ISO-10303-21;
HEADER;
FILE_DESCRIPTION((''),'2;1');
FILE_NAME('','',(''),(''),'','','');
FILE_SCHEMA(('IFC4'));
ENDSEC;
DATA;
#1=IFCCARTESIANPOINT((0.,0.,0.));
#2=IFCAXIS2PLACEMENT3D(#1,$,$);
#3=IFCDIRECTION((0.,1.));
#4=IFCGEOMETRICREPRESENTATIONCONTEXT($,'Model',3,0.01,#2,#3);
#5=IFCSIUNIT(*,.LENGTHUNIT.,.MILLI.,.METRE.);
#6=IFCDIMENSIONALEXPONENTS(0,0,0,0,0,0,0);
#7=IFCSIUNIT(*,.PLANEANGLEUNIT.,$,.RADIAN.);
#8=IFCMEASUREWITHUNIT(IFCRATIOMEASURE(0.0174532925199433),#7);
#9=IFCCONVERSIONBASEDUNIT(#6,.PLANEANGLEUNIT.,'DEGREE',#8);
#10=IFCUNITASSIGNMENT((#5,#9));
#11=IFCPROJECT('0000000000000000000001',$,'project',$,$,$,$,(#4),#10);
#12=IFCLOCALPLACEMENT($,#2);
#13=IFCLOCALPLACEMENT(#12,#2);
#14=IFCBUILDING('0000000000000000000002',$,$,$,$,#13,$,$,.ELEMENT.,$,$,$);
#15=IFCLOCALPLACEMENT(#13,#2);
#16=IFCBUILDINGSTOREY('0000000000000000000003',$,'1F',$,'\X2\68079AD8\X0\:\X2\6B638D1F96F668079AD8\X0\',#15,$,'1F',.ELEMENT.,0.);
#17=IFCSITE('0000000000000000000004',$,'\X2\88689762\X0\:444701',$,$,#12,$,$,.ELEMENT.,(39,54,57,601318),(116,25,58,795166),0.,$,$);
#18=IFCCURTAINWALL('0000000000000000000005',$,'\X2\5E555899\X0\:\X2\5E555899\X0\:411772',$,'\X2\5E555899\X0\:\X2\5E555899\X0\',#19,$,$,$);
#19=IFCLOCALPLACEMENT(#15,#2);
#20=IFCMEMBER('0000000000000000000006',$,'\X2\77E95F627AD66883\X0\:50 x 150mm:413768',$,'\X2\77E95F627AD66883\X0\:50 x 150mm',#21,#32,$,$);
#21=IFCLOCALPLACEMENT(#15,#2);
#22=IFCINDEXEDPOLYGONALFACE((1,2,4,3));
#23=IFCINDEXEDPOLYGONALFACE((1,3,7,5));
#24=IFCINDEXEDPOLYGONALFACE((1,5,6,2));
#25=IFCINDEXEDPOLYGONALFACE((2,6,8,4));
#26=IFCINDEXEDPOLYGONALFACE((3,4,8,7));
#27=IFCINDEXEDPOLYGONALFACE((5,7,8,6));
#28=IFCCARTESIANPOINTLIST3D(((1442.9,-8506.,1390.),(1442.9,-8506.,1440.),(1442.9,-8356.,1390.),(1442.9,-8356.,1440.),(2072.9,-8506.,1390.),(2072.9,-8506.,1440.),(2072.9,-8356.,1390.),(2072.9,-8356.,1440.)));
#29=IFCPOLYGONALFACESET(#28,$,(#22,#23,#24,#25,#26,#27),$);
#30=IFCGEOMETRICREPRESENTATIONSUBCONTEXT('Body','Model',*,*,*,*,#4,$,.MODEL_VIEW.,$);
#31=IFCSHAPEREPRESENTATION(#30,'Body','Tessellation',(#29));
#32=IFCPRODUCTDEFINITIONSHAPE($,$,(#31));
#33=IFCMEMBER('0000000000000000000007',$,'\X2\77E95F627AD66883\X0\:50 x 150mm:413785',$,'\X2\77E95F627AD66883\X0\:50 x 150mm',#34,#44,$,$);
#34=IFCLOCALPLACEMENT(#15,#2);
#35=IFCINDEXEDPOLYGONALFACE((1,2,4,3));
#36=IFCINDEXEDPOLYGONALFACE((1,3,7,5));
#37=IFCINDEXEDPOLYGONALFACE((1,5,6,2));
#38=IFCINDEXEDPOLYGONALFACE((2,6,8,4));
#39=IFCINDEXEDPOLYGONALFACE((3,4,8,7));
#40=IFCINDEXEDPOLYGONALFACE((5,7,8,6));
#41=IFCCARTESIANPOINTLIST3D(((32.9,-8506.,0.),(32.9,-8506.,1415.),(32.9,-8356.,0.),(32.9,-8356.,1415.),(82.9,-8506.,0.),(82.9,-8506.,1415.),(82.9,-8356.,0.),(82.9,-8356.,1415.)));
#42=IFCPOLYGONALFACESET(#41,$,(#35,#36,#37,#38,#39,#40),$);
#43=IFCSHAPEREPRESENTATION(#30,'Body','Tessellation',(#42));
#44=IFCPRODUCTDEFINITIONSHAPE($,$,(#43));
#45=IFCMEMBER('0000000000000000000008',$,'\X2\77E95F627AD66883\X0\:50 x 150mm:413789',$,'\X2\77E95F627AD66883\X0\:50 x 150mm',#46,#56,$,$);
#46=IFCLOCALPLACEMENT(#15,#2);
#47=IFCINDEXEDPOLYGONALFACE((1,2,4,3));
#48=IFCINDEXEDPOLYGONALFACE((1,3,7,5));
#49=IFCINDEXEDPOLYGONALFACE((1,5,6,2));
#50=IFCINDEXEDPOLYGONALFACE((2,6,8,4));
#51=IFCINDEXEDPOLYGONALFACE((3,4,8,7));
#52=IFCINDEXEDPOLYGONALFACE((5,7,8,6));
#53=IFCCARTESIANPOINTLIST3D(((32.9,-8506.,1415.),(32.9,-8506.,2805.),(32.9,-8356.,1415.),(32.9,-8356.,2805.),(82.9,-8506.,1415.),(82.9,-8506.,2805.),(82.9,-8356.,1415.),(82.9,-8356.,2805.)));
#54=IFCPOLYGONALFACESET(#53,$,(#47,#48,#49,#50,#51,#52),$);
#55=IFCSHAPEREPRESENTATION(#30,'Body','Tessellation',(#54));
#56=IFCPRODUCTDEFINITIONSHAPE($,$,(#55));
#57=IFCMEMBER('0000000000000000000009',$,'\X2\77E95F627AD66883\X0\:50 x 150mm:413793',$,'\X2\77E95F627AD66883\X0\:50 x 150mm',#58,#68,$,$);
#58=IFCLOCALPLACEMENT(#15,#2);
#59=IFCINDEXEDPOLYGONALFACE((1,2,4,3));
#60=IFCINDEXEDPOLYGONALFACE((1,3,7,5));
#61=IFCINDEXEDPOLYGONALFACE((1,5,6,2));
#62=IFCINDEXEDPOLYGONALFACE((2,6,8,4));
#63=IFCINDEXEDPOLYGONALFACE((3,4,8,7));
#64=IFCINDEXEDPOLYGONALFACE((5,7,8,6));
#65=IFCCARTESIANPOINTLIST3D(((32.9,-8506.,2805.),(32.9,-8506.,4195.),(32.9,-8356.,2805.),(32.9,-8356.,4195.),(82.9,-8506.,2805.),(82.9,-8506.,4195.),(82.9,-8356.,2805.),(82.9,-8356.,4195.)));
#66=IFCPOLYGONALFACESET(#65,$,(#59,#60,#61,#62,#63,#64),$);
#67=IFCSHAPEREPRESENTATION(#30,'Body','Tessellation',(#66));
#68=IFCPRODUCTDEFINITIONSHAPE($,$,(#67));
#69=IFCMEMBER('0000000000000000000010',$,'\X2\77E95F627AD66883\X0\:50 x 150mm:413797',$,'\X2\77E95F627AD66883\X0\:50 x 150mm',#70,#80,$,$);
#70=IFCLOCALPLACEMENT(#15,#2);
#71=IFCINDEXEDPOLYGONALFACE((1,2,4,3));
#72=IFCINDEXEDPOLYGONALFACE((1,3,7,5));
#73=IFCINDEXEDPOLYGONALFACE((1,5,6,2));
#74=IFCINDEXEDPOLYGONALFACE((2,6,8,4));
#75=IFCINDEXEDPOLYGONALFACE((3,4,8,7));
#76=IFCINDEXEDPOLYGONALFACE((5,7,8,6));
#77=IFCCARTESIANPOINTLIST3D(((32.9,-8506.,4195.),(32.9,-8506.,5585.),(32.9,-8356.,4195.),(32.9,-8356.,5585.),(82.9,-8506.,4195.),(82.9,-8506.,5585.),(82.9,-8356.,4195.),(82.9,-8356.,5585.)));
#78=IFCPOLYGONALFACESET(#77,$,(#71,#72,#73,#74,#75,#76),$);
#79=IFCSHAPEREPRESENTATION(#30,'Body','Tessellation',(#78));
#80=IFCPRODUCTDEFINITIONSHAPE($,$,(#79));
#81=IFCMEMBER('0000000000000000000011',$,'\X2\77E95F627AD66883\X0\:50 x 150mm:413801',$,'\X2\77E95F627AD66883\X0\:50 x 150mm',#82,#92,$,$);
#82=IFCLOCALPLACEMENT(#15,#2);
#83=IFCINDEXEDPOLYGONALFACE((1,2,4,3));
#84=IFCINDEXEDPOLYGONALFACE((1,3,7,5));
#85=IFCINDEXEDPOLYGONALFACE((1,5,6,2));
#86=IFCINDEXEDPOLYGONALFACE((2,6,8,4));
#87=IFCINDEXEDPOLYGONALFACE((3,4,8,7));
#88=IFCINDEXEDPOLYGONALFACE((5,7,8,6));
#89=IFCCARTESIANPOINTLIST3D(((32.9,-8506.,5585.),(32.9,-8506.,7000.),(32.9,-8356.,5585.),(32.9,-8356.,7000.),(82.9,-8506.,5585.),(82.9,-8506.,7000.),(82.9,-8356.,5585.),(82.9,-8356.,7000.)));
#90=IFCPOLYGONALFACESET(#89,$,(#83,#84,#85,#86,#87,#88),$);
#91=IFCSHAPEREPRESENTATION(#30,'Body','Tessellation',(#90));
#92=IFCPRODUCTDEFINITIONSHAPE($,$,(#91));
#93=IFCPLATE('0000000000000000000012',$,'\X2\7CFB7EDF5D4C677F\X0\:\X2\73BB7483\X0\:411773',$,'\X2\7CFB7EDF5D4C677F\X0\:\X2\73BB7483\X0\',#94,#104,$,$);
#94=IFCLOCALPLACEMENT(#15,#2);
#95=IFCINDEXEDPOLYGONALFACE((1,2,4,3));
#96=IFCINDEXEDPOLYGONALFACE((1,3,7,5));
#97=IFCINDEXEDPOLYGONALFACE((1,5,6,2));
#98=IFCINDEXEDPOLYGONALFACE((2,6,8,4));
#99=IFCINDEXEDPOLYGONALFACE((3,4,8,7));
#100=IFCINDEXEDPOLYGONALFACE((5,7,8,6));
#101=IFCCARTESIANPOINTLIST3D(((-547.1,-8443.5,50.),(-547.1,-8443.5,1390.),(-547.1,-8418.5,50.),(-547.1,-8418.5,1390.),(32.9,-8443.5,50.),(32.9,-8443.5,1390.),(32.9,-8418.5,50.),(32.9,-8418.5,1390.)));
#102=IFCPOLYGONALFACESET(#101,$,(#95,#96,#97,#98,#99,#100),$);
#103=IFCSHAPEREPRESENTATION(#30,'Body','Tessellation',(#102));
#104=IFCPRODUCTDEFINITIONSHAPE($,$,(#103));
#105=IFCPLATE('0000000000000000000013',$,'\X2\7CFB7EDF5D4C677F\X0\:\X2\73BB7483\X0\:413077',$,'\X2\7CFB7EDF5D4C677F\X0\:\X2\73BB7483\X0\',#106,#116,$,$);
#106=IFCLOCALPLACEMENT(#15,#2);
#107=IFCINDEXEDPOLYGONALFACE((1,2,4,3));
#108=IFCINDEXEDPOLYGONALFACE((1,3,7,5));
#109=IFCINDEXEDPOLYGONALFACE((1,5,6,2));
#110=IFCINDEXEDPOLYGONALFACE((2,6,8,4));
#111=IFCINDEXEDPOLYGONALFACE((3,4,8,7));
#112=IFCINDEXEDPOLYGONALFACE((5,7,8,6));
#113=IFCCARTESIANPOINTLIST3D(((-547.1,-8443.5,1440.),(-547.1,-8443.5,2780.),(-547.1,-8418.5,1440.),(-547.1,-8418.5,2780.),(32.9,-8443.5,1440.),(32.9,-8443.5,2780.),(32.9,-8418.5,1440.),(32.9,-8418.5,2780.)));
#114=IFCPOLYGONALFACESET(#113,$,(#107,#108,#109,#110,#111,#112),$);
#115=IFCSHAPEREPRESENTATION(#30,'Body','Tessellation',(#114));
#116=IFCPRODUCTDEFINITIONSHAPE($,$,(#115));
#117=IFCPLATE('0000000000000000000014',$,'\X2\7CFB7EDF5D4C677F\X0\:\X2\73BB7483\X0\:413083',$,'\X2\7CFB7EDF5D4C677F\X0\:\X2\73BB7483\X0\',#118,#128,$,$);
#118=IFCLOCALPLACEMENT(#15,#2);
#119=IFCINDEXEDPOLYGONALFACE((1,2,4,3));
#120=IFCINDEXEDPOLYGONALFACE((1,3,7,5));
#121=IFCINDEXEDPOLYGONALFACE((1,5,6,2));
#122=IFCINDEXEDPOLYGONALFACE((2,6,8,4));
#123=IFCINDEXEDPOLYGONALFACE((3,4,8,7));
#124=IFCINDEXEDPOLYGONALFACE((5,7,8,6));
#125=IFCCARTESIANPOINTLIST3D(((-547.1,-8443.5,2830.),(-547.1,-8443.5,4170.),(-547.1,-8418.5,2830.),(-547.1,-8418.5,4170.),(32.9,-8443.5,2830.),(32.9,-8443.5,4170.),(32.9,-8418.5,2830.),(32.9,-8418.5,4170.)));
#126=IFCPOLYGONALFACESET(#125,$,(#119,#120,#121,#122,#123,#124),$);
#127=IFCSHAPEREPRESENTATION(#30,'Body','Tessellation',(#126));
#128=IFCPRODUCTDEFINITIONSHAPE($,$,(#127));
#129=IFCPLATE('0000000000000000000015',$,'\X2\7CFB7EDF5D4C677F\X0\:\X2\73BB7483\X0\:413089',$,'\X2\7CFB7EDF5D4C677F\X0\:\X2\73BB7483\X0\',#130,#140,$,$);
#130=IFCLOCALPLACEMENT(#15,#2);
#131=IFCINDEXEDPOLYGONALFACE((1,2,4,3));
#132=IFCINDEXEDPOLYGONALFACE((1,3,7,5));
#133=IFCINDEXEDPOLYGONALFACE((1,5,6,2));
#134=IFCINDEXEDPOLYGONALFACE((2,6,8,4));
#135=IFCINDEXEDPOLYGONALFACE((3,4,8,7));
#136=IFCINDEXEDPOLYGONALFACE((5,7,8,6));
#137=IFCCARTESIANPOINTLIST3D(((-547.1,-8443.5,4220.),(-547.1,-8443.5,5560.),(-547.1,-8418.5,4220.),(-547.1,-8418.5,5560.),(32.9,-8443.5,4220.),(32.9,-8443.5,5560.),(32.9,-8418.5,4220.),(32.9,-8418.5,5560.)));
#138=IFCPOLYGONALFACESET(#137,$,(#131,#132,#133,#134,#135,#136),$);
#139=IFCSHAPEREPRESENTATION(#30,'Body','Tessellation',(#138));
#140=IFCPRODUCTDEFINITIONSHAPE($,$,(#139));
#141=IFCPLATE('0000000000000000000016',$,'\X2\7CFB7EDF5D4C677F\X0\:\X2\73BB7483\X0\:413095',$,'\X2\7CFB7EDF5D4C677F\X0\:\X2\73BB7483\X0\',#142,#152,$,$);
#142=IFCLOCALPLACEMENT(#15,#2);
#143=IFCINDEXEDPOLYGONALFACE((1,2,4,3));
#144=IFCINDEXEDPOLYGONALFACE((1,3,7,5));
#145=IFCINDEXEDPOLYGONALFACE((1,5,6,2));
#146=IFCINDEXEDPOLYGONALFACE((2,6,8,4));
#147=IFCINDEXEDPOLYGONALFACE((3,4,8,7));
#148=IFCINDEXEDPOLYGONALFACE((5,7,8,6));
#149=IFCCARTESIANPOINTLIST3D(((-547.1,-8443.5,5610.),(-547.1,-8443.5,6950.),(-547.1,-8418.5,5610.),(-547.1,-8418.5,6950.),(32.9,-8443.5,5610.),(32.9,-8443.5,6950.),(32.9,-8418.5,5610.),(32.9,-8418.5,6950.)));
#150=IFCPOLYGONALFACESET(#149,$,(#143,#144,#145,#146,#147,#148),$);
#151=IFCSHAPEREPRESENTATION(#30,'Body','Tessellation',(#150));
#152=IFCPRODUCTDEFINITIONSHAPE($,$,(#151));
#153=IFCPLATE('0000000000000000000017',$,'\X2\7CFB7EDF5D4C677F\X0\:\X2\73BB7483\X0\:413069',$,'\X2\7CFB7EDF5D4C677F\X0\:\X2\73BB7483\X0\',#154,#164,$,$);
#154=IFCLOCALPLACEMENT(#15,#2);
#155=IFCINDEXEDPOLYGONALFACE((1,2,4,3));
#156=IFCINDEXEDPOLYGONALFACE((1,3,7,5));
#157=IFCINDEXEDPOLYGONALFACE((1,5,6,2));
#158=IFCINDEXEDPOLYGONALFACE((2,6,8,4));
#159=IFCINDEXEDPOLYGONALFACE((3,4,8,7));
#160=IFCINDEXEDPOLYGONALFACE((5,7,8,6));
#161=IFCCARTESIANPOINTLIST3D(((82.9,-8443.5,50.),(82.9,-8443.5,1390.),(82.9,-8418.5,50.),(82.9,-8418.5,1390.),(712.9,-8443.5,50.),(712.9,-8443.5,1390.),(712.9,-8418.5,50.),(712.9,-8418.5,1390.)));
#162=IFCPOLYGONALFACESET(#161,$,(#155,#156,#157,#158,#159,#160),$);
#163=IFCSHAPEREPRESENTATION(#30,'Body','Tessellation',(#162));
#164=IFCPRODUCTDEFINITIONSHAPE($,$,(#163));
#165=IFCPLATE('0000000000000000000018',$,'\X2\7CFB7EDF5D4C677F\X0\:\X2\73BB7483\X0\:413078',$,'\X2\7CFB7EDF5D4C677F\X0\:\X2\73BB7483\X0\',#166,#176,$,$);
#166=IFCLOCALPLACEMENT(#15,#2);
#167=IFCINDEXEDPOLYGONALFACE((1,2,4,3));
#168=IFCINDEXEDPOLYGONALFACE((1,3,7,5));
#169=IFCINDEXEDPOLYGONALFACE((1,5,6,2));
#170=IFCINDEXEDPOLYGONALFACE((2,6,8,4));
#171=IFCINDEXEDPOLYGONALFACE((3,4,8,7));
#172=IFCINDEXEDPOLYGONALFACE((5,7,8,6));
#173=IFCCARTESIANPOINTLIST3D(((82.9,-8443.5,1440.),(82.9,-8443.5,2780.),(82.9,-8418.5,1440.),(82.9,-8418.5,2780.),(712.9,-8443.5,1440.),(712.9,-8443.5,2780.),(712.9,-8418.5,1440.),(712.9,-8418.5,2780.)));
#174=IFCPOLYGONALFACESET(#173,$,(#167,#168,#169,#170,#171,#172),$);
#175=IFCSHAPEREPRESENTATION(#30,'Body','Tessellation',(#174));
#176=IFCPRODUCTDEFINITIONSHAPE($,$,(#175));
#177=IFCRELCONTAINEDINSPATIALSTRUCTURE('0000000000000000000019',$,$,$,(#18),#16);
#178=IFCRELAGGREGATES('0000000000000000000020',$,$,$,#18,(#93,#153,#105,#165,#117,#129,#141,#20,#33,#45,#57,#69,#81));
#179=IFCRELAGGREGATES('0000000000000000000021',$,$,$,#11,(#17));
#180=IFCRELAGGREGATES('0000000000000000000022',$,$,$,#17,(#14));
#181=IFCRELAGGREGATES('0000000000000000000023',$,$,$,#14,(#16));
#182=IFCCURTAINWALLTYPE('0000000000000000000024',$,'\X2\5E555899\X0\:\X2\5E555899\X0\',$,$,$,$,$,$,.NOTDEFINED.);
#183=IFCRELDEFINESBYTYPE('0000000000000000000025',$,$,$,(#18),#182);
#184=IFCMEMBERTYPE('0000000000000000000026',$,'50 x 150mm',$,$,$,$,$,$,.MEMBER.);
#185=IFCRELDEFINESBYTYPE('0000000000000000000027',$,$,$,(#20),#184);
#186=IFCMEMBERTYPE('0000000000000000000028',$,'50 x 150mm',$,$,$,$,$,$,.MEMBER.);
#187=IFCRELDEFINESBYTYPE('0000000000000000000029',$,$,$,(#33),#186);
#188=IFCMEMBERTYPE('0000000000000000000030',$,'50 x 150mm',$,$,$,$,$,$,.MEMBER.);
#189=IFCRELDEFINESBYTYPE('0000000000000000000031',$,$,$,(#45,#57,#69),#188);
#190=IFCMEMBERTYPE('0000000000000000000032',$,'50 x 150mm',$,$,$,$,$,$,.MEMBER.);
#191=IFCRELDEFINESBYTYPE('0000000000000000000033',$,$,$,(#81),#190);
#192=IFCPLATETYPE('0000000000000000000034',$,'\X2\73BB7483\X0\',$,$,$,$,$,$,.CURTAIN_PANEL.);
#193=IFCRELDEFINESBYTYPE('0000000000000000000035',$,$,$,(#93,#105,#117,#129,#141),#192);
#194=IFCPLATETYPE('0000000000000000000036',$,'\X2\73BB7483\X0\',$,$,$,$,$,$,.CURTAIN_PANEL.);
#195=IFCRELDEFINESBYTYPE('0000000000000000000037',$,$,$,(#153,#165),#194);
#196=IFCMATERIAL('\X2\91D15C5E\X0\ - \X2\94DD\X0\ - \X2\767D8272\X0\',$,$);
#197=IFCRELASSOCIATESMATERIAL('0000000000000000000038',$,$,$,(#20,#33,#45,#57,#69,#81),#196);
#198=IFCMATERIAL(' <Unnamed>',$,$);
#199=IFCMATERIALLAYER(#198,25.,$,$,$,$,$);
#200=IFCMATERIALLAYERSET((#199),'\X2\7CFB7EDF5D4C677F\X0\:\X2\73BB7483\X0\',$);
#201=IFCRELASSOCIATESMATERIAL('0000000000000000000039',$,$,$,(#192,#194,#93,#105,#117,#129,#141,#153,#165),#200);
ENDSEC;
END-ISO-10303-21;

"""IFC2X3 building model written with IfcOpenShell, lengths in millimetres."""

from ifc_helpers import new_model, entity, si_unit, converted_unit, direction, frame, origin, origin_2d_with_axis, place, context, subcontext, project, spatial, rectangle, extrude, source, transform, mapped, material, layer, layer_set, layer_usage, type_object, type_shapes, element, aggregate, save


model = new_model("IFC2X3")

# Units and contexts
model_context = context("Model", 3, precision=0.01, world=origin(), true_north=direction((0.0, 1.0)))
body_context = subcontext(model_context, "Body", "Model", "MODEL_VIEW")
ifc_project = project(units=[si_unit("LENGTHUNIT", "METRE", prefix="MILLI"), converted_unit("PLANEANGLEUNIT", "DEGREE", entity("IfcRatioMeasure", 0.0174532925199433), si_unit("PLANEANGLEUNIT", "RADIAN"), dimensions=[0, 0, 0, 0, 0, 0, 0])], contexts=[model_context])

# Site, building, storey
site_placement = place(None, origin())
site = spatial("IfcSite", under=ifc_project, at=site_placement, Name="表面:444701", CompositionType="ELEMENT", RefLatitude=(39, 54, 57, 601318), RefLongitude=(116, 25, 58, 795166), RefElevation=0.0)
building_placement = place(site_placement, origin())
building = spatial("IfcBuilding", under=site, at=building_placement, CompositionType="ELEMENT")
storey_placement = place(building_placement, origin())
storey = spatial("IfcBuildingStorey", under=building, at=storey_placement, Name="1F", ObjectType="标高:正负零标高", LongName="1F", CompositionType="ELEMENT", Elevation=0.0)

# Curtain wall, members, plates
curtain_wall_type = type_object("IfcCurtainWallType", Name="幕墙:幕墙", PredefinedType="NOTDEFINED")
curtain_wall_placement = place(storey_placement, origin())
curtain_wall = element("IfcCurtainWall", 1, at=curtain_wall_placement, inside=storey, type_object=curtain_wall_type, Name="幕墙:幕墙:411772", ObjectType="幕墙:幕墙")
ifc_material_1 = material(Name="金属 - 铝 - 白色")
member_type_1 = type_object("IfcMemberType", Name="50 x 150mm", PredefinedType="MEMBER")
shared_shape_1 = source(origin(), body_context, "Body", "SweptSolid", [
    extrude(rectangle(XDim=150.0, YDim=50.0, at=origin_2d_with_axis()), frame((0.0, 0.0, -630.0), z_axis=(0.0, 0.0, 1.0), x_axis=(0.0, -1.0, 0.0)), (0.0, 0.0, 1.0), 630.0),
])
type_shapes(member_type_1, [shared_shape_1])
member_1_placement = place(storey_placement, frame((2072.9, -8431.0, 1415.0), z_axis=(1.0, 0.0, 0.0), x_axis=(0.0, 0.0, 1.0)))
member_1 = element("IfcMember", 2, at=member_1_placement, type_object=member_type_1, material=ifc_material_1, Name="矩形竖梃:50 x 150mm:413768", ObjectType="矩形竖梃:50 x 150mm", context=body_context, shape_type="MappedRepresentation", body=[
    mapped(shared_shape_1, transform((0.0, 0.0, 0.0), scale=1.0)),
])
member_type_2 = type_object("IfcMemberType", Name="50 x 150mm", PredefinedType="MEMBER")
shared_shape_2 = source(origin(), body_context, "Body", "SweptSolid", [
    extrude(rectangle(XDim=150.0, YDim=50.0, at=origin_2d_with_axis()), frame((0.0, 0.0, -1415.0), z_axis=(0.0, 0.0, 1.0), x_axis=(0.0, -1.0, 0.0)), (0.0, 0.0, 1.0), 1415.0),
])
type_shapes(member_type_2, [shared_shape_2])
member_2_placement = place(storey_placement, frame((57.9, -8431.0, 0.0), z_axis=(0.0, 0.0, -1.0), x_axis=(1.0, 0.0, 0.0)))
member_2 = element("IfcMember", 3, at=member_2_placement, type_object=member_type_2, material=ifc_material_1, Name="矩形竖梃:50 x 150mm:413785", ObjectType="矩形竖梃:50 x 150mm", context=body_context, shape_type="MappedRepresentation", body=[
    mapped(shared_shape_2, transform((0.0, 0.0, 0.0), scale=1.0)),
])
member_type_3 = type_object("IfcMemberType", Name="50 x 150mm", PredefinedType="MEMBER")
shared_shape_3 = source(origin(), body_context, "Body", "SweptSolid", [
    extrude(rectangle(XDim=150.0, YDim=50.0, at=origin_2d_with_axis()), frame((0.0, 0.0, -1390.0), z_axis=(0.0, 0.0, 1.0), x_axis=(0.0, -1.0, 0.0)), (0.0, 0.0, 1.0), 1390.0),
])
type_shapes(member_type_3, [shared_shape_3])
member_3_placement = place(storey_placement, frame((57.9, -8431.0, 1415.0), z_axis=(0.0, 0.0, -1.0), x_axis=(1.0, 0.0, 0.0)))
member_3 = element("IfcMember", 4, at=member_3_placement, type_object=member_type_3, material=ifc_material_1, Name="矩形竖梃:50 x 150mm:413789", ObjectType="矩形竖梃:50 x 150mm", context=body_context, shape_type="MappedRepresentation", body=[
    mapped(shared_shape_3, transform((0.0, 0.0, 0.0), scale=1.0)),
])
member_4_placement = place(storey_placement, frame((57.9, -8431.0, 2805.0), z_axis=(0.0, 0.0, -1.0), x_axis=(1.0, 0.0, 0.0)))
member_4 = element("IfcMember", 5, at=member_4_placement, type_object=member_type_3, material=ifc_material_1, Name="矩形竖梃:50 x 150mm:413793", ObjectType="矩形竖梃:50 x 150mm", context=body_context, shape_type="MappedRepresentation", body=[
    mapped(shared_shape_3, transform((0.0, 0.0, 0.0), scale=1.0)),
])
member_5_placement = place(storey_placement, frame((57.9, -8431.0, 4195.0), z_axis=(0.0, 0.0, -1.0), x_axis=(1.0, 0.0, 0.0)))
member_5 = element("IfcMember", 6, at=member_5_placement, type_object=member_type_3, material=ifc_material_1, Name="矩形竖梃:50 x 150mm:413797", ObjectType="矩形竖梃:50 x 150mm", context=body_context, shape_type="MappedRepresentation", body=[
    mapped(shared_shape_3, transform((0.0, 0.0, 0.0), scale=1.0)),
])
member_type_4 = type_object("IfcMemberType", Name="50 x 150mm", PredefinedType="MEMBER")
shared_shape_4 = source(origin(), body_context, "Body", "SweptSolid", [
    extrude(rectangle(XDim=150.0, YDim=50.0, at=origin_2d_with_axis()), frame((0.0, 0.0, -1415.0), z_axis=(0.0, 0.0, 1.0), x_axis=(0.0, -1.0, 0.0)), (0.0, 0.0, 1.0), 1415.0),
])
type_shapes(member_type_4, [shared_shape_4])
member_6_placement = place(storey_placement, frame((57.9, -8431.0, 5585.0), z_axis=(0.0, 0.0, -1.0), x_axis=(1.0, 0.0, 0.0)))
member_6 = element("IfcMember", 7, at=member_6_placement, type_object=member_type_4, material=ifc_material_1, Name="矩形竖梃:50 x 150mm:413801", ObjectType="矩形竖梃:50 x 150mm", context=body_context, shape_type="MappedRepresentation", body=[
    mapped(shared_shape_4, transform((0.0, 0.0, 0.0), scale=1.0)),
])
ifc_material_2 = material(Name=" <Unnamed>")
ifc_layer_1 = layer(ifc_material_2, 25.0)
ifc_layer_set_1 = layer_set([ifc_layer_1], Name="系统嵌板:玻璃")
ifc_layer_usage_1 = layer_usage(ifc_layer_set_1, "AXIS3", "POSITIVE", 0.0)
plate_type_1 = type_object("IfcPlateType", Name="玻璃", PredefinedType="CURTAIN_PANEL", material=ifc_layer_set_1)
shared_shape_5 = source(origin(), body_context, "Body", "SweptSolid", [
    extrude(rectangle(XDim=25.0, YDim=580.0, at=origin_2d_with_axis()), frame((0.0, 0.0, 0.0), z_axis=(0.0, 0.0, 1.0), x_axis=(0.0, 1.0, 0.0)), (0.0, 0.0, 1.0), 1340.0),
])
type_shapes(plate_type_1, [shared_shape_5])
plate_1_placement = place(curtain_wall_placement, frame((-257.1, -8431.0, 50.0)))
plate_1 = element("IfcPlate", 8, at=plate_1_placement, type_object=plate_type_1, material=ifc_layer_usage_1, Name="系统嵌板:玻璃:411773", ObjectType="系统嵌板:玻璃", context=body_context, shape_type="MappedRepresentation", body=[
    mapped(shared_shape_5, transform((0.0, 0.0, 0.0), scale=1.0)),
])
ifc_layer_usage_2 = layer_usage(ifc_layer_set_1, "AXIS3", "POSITIVE", 0.0)
plate_2_placement = place(curtain_wall_placement, frame((-257.1, -8431.0, 1440.0)))
plate_2 = element("IfcPlate", 9, at=plate_2_placement, type_object=plate_type_1, material=ifc_layer_usage_2, Name="系统嵌板:玻璃:413077", ObjectType="系统嵌板:玻璃", context=body_context, shape_type="MappedRepresentation", body=[
    mapped(shared_shape_5, transform((0.0, 0.0, 0.0), scale=1.0)),
])
ifc_layer_usage_3 = layer_usage(ifc_layer_set_1, "AXIS3", "POSITIVE", 0.0)
plate_3_placement = place(curtain_wall_placement, frame((-257.1, -8431.0, 2830.0)))
plate_3 = element("IfcPlate", 10, at=plate_3_placement, type_object=plate_type_1, material=ifc_layer_usage_3, Name="系统嵌板:玻璃:413083", ObjectType="系统嵌板:玻璃", context=body_context, shape_type="MappedRepresentation", body=[
    mapped(shared_shape_5, transform((0.0, 0.0, 0.0), scale=1.0)),
])
ifc_layer_usage_4 = layer_usage(ifc_layer_set_1, "AXIS3", "POSITIVE", 0.0)
plate_4_placement = place(curtain_wall_placement, frame((-257.1, -8431.0, 4220.0)))
plate_4 = element("IfcPlate", 11, at=plate_4_placement, type_object=plate_type_1, material=ifc_layer_usage_4, Name="系统嵌板:玻璃:413089", ObjectType="系统嵌板:玻璃", context=body_context, shape_type="MappedRepresentation", body=[
    mapped(shared_shape_5, transform((0.0, 0.0, 0.0), scale=1.0)),
])
ifc_layer_usage_5 = layer_usage(ifc_layer_set_1, "AXIS3", "POSITIVE", 0.0)
plate_5_placement = place(curtain_wall_placement, frame((-257.1, -8431.0, 5610.0)))
plate_5 = element("IfcPlate", 12, at=plate_5_placement, type_object=plate_type_1, material=ifc_layer_usage_5, Name="系统嵌板:玻璃:413095", ObjectType="系统嵌板:玻璃", context=body_context, shape_type="MappedRepresentation", body=[
    mapped(shared_shape_5, transform((0.0, 0.0, 0.0), scale=1.0)),
])
ifc_layer_usage_6 = layer_usage(ifc_layer_set_1, "AXIS3", "POSITIVE", 0.0)
plate_type_2 = type_object("IfcPlateType", Name="玻璃", PredefinedType="CURTAIN_PANEL", material=ifc_layer_set_1)
shared_shape_6 = source(origin(), body_context, "Body", "SweptSolid", [
    extrude(rectangle(XDim=25.0, YDim=630.0, at=origin_2d_with_axis()), frame((0.0, 0.0, 0.0), z_axis=(0.0, 0.0, 1.0), x_axis=(0.0, 1.0, 0.0)), (0.0, 0.0, 1.0), 1340.0),
])
type_shapes(plate_type_2, [shared_shape_6])
plate_6_placement = place(curtain_wall_placement, frame((397.9, -8431.0, 50.0)))
plate_6 = element("IfcPlate", 13, at=plate_6_placement, type_object=plate_type_2, material=ifc_layer_usage_6, Name="系统嵌板:玻璃:413069", ObjectType="系统嵌板:玻璃", context=body_context, shape_type="MappedRepresentation", body=[
    mapped(shared_shape_6, transform((0.0, 0.0, 0.0), scale=1.0)),
])
ifc_layer_usage_7 = layer_usage(ifc_layer_set_1, "AXIS3", "POSITIVE", 0.0)
plate_7_placement = place(curtain_wall_placement, frame((397.9, -8431.0, 1440.0)))
plate_7 = element("IfcPlate", 14, at=plate_7_placement, type_object=plate_type_2, material=ifc_layer_usage_7, Name="系统嵌板:玻璃:413078", ObjectType="系统嵌板:玻璃", context=body_context, shape_type="MappedRepresentation", body=[
    mapped(shared_shape_6, transform((0.0, 0.0, 0.0), scale=1.0)),
])
aggregate(curtain_wall, [plate_1, plate_6, plate_2, plate_7, plate_3, plate_4, plate_5, member_1, member_2, member_3, member_4, member_5, member_6])

save(model, "model.ifc")
